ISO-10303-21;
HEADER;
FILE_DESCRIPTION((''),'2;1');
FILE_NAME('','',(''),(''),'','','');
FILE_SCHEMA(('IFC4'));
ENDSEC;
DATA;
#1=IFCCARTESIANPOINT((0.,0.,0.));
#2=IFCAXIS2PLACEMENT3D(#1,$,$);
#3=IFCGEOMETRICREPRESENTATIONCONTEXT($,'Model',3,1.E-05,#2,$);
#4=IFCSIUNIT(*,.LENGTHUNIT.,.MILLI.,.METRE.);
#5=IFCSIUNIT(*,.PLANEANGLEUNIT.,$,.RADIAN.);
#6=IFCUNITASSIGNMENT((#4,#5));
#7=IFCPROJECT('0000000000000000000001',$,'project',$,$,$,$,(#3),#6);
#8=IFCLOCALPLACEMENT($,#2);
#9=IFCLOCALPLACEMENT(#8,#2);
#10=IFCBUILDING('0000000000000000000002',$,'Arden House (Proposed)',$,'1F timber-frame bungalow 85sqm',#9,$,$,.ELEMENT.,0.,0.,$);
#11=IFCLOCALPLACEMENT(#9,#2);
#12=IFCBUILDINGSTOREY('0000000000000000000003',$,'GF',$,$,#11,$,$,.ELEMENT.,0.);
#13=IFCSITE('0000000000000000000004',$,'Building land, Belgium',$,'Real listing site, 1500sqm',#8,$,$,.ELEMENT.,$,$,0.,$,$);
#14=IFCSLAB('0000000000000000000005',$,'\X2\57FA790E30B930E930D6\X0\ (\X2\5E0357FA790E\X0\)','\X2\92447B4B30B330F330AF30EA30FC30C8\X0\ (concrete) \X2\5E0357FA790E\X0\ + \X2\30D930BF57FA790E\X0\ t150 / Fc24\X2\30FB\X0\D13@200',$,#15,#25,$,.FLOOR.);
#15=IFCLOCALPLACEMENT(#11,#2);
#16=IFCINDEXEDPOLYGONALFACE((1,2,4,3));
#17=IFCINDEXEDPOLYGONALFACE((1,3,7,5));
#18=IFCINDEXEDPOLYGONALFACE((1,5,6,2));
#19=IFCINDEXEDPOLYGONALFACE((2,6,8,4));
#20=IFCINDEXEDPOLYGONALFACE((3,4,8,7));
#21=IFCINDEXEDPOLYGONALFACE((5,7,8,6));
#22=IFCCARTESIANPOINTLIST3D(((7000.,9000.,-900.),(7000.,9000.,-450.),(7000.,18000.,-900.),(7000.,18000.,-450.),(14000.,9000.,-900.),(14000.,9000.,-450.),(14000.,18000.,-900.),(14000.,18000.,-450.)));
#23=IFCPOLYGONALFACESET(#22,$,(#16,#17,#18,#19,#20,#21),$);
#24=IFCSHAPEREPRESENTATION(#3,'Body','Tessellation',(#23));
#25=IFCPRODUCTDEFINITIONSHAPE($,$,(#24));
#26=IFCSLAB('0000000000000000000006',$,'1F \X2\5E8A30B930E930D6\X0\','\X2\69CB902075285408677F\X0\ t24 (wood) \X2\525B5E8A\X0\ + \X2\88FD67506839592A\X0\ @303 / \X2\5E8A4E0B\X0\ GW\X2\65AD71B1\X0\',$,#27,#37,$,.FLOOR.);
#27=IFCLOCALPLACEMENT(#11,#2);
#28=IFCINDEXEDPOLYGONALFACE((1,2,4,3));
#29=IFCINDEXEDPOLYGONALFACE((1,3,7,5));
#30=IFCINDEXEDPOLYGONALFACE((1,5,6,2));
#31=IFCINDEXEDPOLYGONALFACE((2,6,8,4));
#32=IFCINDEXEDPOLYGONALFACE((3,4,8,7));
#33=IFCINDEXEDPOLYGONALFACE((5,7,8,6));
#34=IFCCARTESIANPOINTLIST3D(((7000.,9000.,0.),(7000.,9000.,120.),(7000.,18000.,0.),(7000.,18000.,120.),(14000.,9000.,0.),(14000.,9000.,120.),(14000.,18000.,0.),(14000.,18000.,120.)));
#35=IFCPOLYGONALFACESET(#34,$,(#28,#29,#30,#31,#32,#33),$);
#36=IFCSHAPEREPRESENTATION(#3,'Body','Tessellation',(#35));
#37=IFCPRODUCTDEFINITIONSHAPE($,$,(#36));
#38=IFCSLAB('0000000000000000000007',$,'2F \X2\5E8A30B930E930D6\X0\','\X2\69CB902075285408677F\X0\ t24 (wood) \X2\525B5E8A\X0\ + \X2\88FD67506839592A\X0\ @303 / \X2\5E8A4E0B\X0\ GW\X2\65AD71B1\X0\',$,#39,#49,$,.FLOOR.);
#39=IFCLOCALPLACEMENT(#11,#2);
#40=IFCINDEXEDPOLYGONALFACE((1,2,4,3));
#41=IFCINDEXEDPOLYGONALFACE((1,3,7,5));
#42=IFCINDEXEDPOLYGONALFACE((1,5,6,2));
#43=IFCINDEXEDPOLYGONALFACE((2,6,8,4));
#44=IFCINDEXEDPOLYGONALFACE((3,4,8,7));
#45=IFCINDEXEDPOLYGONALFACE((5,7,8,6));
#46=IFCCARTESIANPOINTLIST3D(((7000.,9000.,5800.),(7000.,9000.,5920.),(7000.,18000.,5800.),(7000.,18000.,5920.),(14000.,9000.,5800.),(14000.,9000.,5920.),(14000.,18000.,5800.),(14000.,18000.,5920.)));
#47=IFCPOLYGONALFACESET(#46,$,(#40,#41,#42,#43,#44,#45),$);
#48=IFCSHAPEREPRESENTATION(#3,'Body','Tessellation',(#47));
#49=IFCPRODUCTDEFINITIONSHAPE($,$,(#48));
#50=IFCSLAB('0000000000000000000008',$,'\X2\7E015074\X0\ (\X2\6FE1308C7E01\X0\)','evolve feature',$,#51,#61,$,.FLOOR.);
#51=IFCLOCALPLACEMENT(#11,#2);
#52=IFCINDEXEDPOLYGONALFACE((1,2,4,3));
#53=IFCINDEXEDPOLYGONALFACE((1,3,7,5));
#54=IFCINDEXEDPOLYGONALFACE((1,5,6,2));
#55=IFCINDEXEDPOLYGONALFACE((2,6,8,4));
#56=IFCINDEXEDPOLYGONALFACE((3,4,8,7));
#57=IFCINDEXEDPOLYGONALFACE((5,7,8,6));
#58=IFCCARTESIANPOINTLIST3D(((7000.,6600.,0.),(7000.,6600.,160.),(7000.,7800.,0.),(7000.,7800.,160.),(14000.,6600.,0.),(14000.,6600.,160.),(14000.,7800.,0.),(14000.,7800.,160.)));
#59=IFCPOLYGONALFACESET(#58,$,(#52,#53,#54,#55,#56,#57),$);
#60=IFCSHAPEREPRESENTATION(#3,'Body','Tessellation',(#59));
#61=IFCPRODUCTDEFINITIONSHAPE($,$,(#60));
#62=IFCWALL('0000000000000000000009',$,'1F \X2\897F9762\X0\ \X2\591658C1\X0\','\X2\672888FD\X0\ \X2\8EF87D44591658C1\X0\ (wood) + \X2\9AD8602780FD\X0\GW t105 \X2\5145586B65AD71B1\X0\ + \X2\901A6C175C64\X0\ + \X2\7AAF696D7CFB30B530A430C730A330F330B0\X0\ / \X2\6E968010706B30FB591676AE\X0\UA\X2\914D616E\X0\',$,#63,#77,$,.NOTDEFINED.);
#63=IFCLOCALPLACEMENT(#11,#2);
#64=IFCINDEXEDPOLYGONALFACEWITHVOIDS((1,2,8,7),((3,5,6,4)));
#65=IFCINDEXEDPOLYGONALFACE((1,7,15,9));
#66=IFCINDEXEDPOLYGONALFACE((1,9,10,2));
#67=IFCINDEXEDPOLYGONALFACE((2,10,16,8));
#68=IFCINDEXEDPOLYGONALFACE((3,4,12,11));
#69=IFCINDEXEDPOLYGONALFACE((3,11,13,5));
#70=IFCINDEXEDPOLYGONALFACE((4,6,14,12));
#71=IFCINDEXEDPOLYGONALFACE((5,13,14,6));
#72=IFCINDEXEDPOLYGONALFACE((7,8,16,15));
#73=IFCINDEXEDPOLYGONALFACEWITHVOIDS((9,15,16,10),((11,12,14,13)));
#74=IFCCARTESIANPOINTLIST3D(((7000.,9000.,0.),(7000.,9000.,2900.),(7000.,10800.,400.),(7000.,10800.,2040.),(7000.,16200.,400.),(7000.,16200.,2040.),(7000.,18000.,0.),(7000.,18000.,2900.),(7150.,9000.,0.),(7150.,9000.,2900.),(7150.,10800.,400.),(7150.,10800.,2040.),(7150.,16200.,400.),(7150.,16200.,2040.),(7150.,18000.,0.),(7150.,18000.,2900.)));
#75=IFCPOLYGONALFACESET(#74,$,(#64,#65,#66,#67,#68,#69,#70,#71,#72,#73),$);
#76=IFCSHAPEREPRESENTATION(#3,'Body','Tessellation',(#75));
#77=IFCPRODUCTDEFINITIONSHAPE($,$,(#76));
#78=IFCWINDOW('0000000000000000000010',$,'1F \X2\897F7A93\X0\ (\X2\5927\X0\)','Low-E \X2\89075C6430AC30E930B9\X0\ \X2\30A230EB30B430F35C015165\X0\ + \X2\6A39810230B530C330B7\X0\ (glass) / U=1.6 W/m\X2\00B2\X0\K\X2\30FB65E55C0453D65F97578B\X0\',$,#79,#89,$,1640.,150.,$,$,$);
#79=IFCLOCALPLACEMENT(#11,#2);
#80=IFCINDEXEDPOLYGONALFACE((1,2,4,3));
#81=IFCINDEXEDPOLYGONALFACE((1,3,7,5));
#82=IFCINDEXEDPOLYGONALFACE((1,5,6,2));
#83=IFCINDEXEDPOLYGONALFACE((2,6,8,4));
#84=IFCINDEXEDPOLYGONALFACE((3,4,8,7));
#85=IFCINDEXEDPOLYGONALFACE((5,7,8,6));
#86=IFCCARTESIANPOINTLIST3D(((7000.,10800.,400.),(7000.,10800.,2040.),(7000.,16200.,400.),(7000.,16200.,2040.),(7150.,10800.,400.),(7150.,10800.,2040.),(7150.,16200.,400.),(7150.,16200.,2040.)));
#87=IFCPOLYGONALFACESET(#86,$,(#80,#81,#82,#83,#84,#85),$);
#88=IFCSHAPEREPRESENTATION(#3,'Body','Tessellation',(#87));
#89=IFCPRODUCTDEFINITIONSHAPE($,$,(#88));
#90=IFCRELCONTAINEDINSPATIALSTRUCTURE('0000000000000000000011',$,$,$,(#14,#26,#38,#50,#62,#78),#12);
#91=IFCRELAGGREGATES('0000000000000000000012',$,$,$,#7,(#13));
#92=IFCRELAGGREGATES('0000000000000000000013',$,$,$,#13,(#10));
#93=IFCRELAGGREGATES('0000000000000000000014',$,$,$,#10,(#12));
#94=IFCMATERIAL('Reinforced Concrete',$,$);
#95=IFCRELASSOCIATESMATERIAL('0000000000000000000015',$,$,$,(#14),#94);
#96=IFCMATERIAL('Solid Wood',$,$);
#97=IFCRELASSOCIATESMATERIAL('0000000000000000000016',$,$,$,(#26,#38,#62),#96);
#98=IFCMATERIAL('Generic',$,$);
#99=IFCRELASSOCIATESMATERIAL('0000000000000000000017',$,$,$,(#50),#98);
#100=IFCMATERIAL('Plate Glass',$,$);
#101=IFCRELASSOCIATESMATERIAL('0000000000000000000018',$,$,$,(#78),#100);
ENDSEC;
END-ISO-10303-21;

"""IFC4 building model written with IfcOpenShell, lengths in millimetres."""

from ifc_helpers import new_model, si_unit, frame, frame_2d, origin, place, context, project, spatial, rectangle, extrude, material, element, fill, save


model = new_model("IFC4")

# Units and contexts
model_context = context("Model", 3, precision=1e-05, world=origin())
ifc_project = project(units=[si_unit("LENGTHUNIT", "METRE", prefix="MILLI"), si_unit("PLANEANGLEUNIT", "RADIAN")], contexts=[model_context])

# Site, building, storey
site_placement = place(None, origin())
site = spatial("IfcSite", under=ifc_project, at=site_placement, Name="Building land, Belgium", ObjectType="Real listing site, 1500sqm", CompositionType="ELEMENT", RefElevation=0.0)
building_placement = place(site_placement, origin())
building = spatial("IfcBuilding", under=site, at=building_placement, Name="Arden House (Proposed)", ObjectType="1F timber-frame bungalow 85sqm", CompositionType="ELEMENT", ElevationOfRefHeight=0.0, ElevationOfTerrain=0.0)
storey_placement = place(building_placement, origin())
storey = spatial("IfcBuildingStorey", under=building, at=storey_placement, Name="GF", CompositionType="ELEMENT", Elevation=0.0)

# Slabs
ifc_material_1 = material(Name="Reinforced Concrete")
slab_1_placement = place(storey_placement, frame((3500.0, 4500.0, -450.0)))
element("IfcSlab", 1, at=slab_1_placement, inside=storey, material=ifc_material_1, Name="基礎スラブ (布基礎)", Description="鉄筋コンクリート (concrete) 布基礎 + ベタ基礎 t150 / Fc24・D13@200", PredefinedType="FLOOR", context=model_context, shape_type="SweptSolid", body=[
    extrude(rectangle(XDim=7000.0, YDim=9000.0, at=frame_2d((3500.0, 4500.0))), frame((3500.0, 4500.0, -450.0)), (0.0, 0.0, 1.0), 450.0),
])
ifc_material_2 = material(Name="Solid Wood")
slab_2_placement = place(storey_placement, frame((3500.0, 4500.0, 0.0)))
element("IfcSlab", 2, at=slab_2_placement, inside=storey, material=ifc_material_2, Name="1F 床スラブ", Description="構造用合板 t24 (wood) 剛床 + 製材根太 @303 / 床下 GW断熱", PredefinedType="FLOOR", context=model_context, shape_type="SweptSolid", body=[
    extrude(rectangle(XDim=7000.0, YDim=9000.0, at=frame_2d((3500.0, 4500.0))), frame((3500.0, 4500.0, 0.0)), (0.0, 0.0, 1.0), 120.0),
])
slab_3_placement = place(storey_placement, frame((3500.0, 4500.0, 2900.0)))
element("IfcSlab", 3, at=slab_3_placement, inside=storey, material=ifc_material_2, Name="2F 床スラブ", Description="構造用合板 t24 (wood) 剛床 + 製材根太 @303 / 床下 GW断熱", PredefinedType="FLOOR", context=model_context, shape_type="SweptSolid", body=[
    extrude(rectangle(XDim=7000.0, YDim=9000.0, at=frame_2d((3500.0, 4500.0))), frame((3500.0, 4500.0, 2900.0)), (0.0, 0.0, 1.0), 120.0),
])
ifc_material_3 = material(Name="Generic")
slab_4_placement = place(storey_placement, frame((3500.0, 3300.0, 0.0)))
element("IfcSlab", 4, at=slab_4_placement, inside=storey, material=ifc_material_3, Name="縁側 (濡れ縁)", Description="evolve feature", PredefinedType="FLOOR", context=model_context, shape_type="SweptSolid", body=[
    extrude(rectangle(XDim=7000.0, YDim=1200.0, at=frame_2d((3500.0, 600.0))), frame((3500.0, 3300.0, 0.0)), (0.0, 0.0, 1.0), 160.0),
])

# Shared definitions
ifc_material_4 = material(Name="Plate Glass")

# Wall, opening, window
wall_1_placement = place(storey_placement, frame((3500.0, 4500.0, 0.0)))
wall_1 = element("IfcWall", 5, at=wall_1_placement, inside=storey, material=ifc_material_2, Name="1F 西面 外壁", Description="木製 軸組外壁 (wood) + 高性能GW t105 充填断熱 + 通気層 + 窯業系サイディング / 準耐火・外皮UA配慮", PredefinedType="NOTDEFINED", context=model_context, shape_type="SweptSolid", body=[
    extrude(rectangle(XDim=150.0, YDim=9000.0, at=frame_2d((75.0, 4500.0))), frame((3500.0, 4500.0, 0.0)), (0.0, 0.0, 1.0), 2900.0),
])
opening_1_placement = place(storey_placement, frame((3500.0, 5400.0, 200.0)))
opening_1 = element("IfcOpeningElement", 6, at=opening_1_placement, cuts=wall_1, PredefinedType="NOTDEFINED", context=model_context, shape_type="SweptSolid", body=[
    extrude(rectangle(XDim=150.0, YDim=5400.0, at=frame_2d((75.0, 2700.0))), frame((3500.0, 5400.0, 200.0)), (0.0, 0.0, 1.0), 1640.0),
])
window_1_placement = place(storey_placement, frame((3500.0, 5400.0, 200.0)))
window_1 = element("IfcWindow", 7, at=window_1_placement, inside=storey, material=ifc_material_4, Name="1F 西窓 (大)", Description="Low-E 複層ガラス アルゴン封入 + 樹脂サッシ (glass) / U=1.6 W/m²K・日射取得型", OverallHeight=1640.0, OverallWidth=150.0, context=model_context, shape_type="SweptSolid", body=[
    extrude(rectangle(XDim=150.0, YDim=5400.0, at=frame_2d((75.0, 2700.0))), frame((3500.0, 5400.0, 200.0)), (0.0, 0.0, 1.0), 1640.0),
])
fill(opening_1, window_1)

save(model, "model.ifc")
